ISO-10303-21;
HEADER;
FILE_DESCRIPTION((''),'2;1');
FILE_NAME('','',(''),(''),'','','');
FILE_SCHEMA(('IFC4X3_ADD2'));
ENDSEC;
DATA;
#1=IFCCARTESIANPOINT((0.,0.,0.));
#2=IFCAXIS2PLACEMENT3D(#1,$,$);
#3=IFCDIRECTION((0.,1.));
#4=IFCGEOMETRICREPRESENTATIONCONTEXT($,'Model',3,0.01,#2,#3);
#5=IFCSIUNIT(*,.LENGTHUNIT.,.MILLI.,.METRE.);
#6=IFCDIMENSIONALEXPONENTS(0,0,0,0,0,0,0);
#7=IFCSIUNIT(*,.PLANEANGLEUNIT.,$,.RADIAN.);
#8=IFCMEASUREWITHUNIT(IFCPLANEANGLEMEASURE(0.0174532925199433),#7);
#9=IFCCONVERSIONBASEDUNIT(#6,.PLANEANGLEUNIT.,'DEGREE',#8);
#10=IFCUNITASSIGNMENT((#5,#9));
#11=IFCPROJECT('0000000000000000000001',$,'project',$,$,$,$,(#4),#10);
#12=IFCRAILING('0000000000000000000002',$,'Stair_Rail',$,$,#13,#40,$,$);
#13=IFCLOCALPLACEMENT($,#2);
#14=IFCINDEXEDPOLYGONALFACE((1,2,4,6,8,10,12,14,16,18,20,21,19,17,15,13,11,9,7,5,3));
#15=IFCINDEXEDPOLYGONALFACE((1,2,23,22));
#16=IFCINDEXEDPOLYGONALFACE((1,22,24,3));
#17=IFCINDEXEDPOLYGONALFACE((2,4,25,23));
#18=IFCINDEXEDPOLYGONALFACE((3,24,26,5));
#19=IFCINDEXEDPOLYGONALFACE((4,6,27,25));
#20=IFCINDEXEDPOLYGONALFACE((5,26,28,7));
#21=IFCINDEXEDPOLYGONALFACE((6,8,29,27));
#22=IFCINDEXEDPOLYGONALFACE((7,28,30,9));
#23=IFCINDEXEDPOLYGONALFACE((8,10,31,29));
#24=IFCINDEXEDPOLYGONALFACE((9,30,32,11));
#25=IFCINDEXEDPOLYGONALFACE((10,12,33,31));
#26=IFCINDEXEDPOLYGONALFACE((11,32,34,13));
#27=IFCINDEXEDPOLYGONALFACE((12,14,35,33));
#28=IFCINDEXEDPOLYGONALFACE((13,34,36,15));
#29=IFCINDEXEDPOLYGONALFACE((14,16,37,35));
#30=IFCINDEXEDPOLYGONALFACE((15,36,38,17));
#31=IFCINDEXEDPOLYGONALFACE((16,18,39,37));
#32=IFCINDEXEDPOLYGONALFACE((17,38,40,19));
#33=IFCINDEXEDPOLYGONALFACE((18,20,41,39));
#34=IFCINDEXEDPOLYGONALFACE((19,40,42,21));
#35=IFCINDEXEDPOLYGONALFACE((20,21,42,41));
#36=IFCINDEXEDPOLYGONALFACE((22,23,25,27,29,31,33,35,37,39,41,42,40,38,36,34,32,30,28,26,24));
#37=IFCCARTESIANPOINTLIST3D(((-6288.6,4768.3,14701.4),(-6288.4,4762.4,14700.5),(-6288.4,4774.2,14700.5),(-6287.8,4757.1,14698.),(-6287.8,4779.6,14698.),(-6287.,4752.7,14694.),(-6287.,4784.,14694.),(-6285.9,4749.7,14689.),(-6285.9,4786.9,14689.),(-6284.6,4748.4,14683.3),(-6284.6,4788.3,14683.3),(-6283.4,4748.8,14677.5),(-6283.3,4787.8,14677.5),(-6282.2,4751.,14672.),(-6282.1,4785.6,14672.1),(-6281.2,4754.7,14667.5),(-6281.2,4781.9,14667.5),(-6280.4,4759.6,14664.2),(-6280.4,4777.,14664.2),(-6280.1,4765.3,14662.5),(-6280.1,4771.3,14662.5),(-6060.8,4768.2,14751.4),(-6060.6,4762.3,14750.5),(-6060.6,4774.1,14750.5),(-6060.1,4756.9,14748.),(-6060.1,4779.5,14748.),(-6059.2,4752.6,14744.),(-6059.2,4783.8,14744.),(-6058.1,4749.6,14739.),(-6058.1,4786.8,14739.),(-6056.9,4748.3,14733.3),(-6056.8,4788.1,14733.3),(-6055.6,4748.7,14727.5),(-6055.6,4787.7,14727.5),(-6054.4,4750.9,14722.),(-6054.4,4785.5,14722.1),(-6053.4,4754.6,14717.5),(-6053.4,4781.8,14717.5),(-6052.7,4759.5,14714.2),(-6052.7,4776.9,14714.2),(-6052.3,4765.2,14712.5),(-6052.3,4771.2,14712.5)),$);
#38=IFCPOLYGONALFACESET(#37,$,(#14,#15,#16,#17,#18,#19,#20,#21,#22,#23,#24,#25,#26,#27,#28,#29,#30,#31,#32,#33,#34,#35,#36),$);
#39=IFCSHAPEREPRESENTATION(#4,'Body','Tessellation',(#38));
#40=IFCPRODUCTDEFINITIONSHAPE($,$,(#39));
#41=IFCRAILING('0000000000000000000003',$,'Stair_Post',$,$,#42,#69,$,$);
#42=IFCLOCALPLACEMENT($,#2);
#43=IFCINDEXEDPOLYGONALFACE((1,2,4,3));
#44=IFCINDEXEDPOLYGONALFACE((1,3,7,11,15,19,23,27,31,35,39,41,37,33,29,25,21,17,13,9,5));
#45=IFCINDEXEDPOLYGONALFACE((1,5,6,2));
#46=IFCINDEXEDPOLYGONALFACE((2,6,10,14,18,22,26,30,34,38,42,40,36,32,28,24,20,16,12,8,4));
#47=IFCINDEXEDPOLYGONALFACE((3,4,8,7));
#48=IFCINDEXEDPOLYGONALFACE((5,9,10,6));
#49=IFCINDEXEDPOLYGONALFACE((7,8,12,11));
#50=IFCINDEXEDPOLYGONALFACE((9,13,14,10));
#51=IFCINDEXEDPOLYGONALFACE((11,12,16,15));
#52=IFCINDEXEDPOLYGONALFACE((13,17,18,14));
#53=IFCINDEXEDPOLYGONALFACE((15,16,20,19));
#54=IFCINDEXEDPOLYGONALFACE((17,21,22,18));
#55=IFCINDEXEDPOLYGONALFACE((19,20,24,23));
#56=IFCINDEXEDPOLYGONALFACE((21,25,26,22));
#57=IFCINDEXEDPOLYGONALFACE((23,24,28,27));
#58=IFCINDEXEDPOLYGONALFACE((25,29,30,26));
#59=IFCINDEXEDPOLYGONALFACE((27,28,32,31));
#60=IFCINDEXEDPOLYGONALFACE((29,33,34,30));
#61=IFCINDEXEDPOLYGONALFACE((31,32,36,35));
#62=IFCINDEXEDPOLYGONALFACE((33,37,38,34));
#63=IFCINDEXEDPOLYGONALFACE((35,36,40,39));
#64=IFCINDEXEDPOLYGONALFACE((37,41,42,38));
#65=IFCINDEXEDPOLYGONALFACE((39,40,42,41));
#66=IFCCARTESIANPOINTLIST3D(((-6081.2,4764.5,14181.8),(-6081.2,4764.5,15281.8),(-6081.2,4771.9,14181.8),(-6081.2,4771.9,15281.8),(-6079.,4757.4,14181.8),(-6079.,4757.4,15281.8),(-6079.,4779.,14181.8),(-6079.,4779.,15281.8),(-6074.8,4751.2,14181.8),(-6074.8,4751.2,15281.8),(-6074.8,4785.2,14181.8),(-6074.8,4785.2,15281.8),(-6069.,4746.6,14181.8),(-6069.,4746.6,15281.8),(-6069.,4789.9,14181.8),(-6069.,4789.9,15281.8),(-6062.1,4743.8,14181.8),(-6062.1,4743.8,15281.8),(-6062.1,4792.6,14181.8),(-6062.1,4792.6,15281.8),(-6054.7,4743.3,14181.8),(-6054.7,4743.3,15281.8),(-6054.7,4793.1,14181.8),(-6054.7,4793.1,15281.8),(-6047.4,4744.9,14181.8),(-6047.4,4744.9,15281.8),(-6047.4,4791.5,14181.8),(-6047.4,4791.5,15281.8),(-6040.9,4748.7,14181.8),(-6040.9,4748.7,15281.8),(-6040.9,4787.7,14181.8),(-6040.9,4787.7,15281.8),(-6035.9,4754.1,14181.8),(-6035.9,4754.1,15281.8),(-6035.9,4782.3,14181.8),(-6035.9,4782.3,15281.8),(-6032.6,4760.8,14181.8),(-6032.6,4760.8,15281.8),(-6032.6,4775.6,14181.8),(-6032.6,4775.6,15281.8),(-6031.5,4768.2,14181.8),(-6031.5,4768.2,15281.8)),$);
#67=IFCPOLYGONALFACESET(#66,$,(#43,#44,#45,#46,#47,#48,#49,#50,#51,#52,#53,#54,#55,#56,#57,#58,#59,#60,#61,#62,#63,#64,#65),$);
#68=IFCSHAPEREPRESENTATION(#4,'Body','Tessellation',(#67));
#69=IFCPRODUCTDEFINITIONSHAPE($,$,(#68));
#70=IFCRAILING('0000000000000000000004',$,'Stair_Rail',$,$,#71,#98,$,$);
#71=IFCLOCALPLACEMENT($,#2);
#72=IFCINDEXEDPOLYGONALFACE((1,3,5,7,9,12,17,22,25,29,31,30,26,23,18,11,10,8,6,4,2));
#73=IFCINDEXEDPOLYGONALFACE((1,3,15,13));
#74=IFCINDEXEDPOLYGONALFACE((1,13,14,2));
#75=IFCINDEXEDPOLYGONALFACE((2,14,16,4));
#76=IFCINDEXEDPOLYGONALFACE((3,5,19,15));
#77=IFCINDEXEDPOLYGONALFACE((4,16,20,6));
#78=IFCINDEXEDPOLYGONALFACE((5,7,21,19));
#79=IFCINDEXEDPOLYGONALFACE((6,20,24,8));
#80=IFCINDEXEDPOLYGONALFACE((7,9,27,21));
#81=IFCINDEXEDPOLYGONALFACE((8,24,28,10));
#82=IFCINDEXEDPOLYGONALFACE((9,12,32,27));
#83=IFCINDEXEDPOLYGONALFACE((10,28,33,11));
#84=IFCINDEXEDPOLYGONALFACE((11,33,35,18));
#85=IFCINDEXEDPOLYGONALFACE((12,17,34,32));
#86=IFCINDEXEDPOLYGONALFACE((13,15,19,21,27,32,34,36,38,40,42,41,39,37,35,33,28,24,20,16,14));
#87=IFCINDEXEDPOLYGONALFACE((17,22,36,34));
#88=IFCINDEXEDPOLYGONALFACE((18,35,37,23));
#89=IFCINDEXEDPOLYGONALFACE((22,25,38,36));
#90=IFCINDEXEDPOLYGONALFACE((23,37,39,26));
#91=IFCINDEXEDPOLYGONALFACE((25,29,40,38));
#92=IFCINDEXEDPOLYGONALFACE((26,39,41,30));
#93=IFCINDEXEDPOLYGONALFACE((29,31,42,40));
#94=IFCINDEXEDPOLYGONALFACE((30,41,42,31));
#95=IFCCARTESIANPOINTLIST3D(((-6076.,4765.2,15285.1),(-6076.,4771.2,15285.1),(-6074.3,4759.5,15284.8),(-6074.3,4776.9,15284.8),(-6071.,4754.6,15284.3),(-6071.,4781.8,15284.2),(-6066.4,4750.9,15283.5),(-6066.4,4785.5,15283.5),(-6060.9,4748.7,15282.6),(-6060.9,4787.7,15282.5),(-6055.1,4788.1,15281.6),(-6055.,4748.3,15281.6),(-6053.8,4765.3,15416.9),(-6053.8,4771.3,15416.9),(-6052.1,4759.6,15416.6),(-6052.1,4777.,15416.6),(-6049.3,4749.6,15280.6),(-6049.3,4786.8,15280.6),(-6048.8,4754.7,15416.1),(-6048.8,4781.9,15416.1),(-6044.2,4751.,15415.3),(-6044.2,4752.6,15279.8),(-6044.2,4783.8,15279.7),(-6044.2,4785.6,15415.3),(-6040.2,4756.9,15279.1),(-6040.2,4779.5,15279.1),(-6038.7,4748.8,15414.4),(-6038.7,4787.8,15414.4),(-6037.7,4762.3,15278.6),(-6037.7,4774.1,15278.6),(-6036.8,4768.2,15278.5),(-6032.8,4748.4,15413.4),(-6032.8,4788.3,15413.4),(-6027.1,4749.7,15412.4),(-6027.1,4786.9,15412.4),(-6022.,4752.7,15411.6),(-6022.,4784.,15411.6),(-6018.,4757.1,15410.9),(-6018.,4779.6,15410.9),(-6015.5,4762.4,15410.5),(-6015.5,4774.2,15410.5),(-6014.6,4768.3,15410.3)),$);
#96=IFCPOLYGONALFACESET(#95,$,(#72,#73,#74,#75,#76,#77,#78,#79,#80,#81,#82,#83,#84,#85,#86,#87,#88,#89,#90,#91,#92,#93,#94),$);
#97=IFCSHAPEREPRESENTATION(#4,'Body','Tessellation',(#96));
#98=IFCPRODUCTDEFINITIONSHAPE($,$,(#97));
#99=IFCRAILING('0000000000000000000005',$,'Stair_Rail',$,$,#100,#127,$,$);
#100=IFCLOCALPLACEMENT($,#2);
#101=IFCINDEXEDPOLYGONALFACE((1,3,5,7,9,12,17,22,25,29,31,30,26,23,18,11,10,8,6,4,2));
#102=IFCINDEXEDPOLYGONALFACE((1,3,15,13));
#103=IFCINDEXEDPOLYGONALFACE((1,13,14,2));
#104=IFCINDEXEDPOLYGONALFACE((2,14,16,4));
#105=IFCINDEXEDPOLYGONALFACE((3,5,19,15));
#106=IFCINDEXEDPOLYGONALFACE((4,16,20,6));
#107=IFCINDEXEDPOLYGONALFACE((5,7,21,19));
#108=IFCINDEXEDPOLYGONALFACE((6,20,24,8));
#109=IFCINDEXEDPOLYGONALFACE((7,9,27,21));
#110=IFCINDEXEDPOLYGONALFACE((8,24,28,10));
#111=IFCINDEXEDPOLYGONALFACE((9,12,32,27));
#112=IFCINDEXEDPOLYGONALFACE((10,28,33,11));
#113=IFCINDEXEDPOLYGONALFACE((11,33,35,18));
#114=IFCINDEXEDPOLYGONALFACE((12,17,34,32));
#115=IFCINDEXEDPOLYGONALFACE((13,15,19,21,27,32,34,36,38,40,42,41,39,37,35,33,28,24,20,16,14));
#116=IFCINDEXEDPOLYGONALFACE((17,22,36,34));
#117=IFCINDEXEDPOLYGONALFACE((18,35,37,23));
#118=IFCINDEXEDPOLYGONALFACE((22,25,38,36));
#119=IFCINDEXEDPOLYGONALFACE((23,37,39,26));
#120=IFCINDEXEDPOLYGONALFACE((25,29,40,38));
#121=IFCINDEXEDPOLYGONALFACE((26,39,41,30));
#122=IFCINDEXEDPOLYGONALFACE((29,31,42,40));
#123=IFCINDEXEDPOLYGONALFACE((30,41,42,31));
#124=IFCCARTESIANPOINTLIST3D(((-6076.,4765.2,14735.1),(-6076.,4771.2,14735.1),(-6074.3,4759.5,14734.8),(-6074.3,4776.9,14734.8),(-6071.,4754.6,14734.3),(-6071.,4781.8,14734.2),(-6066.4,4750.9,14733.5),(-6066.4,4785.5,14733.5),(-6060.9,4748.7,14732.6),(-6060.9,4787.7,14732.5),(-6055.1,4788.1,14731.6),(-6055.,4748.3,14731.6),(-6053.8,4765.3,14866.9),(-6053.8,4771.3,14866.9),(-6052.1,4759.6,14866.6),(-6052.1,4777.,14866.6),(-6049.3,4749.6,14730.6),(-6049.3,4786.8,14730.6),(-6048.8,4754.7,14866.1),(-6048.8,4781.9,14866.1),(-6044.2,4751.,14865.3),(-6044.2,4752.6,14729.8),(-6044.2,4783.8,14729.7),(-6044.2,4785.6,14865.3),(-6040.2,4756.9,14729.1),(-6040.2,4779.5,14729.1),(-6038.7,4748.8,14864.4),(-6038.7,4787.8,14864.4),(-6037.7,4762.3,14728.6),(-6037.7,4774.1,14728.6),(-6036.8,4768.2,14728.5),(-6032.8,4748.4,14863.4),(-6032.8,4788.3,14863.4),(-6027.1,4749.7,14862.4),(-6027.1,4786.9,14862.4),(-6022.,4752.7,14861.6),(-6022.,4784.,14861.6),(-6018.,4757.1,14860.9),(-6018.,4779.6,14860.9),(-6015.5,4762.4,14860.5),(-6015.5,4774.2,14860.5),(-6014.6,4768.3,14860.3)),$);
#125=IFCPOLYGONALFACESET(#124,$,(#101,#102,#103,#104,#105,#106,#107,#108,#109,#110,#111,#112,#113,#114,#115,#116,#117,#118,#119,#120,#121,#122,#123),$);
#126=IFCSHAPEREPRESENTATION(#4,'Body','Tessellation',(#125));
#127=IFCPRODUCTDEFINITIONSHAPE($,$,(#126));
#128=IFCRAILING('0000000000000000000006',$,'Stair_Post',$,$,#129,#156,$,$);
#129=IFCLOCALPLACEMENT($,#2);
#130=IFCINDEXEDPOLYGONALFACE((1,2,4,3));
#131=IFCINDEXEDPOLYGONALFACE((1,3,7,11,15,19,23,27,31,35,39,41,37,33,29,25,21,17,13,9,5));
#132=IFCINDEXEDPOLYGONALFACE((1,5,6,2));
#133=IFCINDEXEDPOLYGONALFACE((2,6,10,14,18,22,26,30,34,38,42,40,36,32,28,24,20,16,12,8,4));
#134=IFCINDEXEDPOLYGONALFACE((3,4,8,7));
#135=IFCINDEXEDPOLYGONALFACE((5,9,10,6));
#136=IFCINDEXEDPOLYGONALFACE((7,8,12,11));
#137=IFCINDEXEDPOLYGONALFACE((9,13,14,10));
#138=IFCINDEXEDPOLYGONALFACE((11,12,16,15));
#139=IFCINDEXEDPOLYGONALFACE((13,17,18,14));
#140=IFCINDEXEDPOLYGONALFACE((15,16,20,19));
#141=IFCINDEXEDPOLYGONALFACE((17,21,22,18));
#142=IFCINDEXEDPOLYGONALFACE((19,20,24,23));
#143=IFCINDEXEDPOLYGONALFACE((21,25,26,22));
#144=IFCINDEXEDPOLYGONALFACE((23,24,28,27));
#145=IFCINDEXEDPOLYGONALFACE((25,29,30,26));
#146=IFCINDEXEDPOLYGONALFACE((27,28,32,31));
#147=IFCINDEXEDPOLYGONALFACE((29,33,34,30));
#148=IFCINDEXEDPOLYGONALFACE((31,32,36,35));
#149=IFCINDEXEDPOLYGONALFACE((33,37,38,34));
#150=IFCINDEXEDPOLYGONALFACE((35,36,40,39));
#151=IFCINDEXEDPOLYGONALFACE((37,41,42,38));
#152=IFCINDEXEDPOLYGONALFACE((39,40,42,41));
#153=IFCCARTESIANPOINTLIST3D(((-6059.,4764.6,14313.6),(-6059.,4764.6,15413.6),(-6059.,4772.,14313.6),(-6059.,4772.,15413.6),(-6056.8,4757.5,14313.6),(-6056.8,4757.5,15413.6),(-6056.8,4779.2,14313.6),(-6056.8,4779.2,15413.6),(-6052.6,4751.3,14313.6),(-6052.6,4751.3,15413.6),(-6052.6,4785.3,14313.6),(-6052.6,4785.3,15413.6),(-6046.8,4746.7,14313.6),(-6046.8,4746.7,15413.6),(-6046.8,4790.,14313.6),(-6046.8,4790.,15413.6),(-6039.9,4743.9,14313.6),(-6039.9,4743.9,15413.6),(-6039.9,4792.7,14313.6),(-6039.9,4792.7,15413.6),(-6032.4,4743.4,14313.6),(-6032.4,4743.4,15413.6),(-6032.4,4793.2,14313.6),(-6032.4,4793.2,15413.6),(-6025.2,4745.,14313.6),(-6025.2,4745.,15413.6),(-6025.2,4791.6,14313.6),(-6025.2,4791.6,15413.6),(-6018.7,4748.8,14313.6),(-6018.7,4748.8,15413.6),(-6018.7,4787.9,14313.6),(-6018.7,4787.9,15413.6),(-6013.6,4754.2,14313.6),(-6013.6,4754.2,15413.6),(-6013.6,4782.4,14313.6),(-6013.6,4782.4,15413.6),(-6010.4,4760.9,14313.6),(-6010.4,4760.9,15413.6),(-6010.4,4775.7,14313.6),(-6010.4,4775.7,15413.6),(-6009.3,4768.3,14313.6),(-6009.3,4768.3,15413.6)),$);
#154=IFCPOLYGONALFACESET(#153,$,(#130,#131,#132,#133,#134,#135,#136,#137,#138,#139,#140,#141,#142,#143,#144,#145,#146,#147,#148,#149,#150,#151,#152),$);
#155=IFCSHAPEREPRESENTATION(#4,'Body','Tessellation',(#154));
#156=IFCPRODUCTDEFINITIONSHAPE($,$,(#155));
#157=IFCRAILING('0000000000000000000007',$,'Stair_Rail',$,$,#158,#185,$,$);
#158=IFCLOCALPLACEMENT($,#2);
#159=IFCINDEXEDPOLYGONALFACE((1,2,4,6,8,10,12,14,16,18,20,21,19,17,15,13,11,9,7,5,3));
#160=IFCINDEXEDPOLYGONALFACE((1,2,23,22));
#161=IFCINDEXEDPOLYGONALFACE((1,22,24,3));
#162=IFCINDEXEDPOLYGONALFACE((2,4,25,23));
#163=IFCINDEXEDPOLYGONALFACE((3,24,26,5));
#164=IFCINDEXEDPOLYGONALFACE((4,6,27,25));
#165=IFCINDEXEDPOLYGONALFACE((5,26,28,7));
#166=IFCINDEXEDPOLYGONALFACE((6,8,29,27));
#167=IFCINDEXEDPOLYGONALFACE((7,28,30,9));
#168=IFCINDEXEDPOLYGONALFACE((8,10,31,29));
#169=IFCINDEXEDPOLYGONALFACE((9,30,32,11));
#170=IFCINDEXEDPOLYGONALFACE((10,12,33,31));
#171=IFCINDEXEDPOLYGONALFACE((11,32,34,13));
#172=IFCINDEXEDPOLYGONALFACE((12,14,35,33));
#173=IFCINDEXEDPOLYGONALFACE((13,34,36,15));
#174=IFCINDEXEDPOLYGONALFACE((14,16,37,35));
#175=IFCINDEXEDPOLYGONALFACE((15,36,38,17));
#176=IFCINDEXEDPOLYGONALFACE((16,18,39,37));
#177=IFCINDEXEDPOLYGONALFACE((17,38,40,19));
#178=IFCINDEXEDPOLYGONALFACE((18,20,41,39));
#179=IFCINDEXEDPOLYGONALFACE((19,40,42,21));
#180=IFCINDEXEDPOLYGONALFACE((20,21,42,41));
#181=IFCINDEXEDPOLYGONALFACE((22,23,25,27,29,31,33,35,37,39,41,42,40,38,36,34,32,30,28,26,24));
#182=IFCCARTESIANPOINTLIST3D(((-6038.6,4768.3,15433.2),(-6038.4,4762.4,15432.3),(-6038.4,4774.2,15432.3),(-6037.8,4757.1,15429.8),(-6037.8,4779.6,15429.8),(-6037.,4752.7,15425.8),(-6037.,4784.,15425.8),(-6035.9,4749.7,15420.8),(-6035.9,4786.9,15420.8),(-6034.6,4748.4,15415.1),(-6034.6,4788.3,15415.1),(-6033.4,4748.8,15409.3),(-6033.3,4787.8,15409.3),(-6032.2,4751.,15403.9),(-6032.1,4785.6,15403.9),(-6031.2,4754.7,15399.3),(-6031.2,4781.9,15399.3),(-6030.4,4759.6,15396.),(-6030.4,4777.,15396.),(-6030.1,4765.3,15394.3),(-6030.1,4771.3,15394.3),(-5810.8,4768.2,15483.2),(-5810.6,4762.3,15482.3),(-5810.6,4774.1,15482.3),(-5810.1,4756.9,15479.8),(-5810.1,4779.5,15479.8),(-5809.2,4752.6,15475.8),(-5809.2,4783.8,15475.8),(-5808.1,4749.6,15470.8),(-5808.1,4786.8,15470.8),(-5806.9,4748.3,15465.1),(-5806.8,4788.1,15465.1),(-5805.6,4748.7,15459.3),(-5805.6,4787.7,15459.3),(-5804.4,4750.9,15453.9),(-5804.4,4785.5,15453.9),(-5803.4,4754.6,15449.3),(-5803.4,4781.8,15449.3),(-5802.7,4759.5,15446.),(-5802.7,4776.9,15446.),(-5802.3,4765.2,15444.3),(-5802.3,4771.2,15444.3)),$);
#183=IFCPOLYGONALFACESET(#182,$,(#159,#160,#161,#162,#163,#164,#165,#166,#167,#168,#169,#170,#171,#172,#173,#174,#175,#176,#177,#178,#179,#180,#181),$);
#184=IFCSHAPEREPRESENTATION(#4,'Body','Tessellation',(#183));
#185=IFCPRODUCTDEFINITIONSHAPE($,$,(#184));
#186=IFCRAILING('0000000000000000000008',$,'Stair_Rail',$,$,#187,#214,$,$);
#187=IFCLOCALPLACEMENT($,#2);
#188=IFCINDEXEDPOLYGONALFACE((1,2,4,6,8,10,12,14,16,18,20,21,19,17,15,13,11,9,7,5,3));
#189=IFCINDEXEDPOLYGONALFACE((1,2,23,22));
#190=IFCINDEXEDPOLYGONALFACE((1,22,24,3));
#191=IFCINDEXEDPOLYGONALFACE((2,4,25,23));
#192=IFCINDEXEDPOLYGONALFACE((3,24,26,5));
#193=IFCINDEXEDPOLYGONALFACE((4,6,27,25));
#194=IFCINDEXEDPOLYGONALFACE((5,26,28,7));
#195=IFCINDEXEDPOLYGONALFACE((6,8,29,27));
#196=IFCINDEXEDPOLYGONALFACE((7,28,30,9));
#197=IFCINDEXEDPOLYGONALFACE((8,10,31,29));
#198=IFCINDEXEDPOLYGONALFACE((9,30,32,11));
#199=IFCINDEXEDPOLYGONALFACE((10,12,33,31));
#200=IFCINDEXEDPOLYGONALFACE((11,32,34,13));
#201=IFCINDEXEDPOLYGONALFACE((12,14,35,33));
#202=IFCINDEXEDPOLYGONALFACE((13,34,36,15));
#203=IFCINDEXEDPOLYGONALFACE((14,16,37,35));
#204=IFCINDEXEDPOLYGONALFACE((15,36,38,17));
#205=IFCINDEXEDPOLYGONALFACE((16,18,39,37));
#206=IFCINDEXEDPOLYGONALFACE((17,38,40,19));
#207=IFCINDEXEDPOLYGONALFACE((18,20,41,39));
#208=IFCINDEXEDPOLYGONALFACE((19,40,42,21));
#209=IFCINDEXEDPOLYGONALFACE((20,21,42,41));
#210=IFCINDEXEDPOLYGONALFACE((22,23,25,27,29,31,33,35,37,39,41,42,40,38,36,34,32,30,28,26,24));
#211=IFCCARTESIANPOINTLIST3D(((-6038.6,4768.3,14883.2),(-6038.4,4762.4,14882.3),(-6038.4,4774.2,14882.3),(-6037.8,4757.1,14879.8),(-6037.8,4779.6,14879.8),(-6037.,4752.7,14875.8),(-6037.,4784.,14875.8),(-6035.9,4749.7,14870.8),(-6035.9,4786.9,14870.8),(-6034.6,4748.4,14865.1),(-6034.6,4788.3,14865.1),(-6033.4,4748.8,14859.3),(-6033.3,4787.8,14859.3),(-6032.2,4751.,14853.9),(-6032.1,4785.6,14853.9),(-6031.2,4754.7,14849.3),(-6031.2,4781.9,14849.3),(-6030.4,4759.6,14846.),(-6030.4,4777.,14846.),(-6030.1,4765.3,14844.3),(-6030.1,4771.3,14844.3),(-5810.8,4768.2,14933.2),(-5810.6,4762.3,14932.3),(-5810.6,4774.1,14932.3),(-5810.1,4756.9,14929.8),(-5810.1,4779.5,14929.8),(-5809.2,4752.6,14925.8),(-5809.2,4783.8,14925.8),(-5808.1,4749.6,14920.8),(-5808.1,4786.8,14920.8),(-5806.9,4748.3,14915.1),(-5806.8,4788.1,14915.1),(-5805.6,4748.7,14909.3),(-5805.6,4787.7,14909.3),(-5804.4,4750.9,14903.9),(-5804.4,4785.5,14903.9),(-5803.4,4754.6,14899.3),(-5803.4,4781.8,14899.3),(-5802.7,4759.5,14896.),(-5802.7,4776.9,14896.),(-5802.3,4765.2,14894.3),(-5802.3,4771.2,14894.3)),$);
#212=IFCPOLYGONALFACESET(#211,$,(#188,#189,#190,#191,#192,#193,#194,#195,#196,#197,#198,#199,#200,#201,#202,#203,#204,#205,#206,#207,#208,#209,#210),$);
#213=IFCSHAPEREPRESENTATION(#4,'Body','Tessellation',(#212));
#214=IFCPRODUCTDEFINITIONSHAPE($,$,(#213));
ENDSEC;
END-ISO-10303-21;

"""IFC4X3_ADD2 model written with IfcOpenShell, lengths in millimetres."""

from ifc_helpers import new_model, entity, si_unit, converted_unit, direction, frame, origin, context, project, circle, extrude, element, save


model = new_model("IFC4X3_ADD2")

# Units and contexts
model_context = context("Model", 3, precision=0.01, world=origin(), true_north=direction((0.0, 1.0)))
ifc_project = project(units=[si_unit("LENGTHUNIT", "METRE", prefix="MILLI"), converted_unit("PLANEANGLEUNIT", "DEGREE", entity("IfcPlaneAngleMeasure", 0.0174532925199433), si_unit("PLANEANGLEUNIT", "RADIAN"), dimensions=[0, 0, 0, 0, 0, 0, 0])], contexts=[model_context])

# Railings
element("IfcRailing", 1, Name="Stair_Rail", context=model_context, shape_type="SweptSolid", body=[
    entity("IfcSweptDiskSolid", entity("IfcPolyline", [entity("IfcCartesianPoint", [-6284.3, 4768.3, 14681.8]), entity("IfcCartesianPoint", [-6056.5, 4768.2, 14731.8])]), 20.0),
])
element("IfcRailing", 2, Name="Stair_Post", context=model_context, shape_type="SweptSolid", body=[
    extrude(circle(Radius=25.0), frame((-6056.5, 4768.2, 14181.8)), (0.0, 0.0, 1.0), 1100.0),
])
element("IfcRailing", 3, Name="Stair_Rail", context=model_context, shape_type="SweptSolid", body=[
    entity("IfcSweptDiskSolid", entity("IfcPolyline", [entity("IfcCartesianPoint", [-6056.5, 4768.2, 15281.8]), entity("IfcCartesianPoint", [-6034.3, 4768.3, 15413.6])]), 20.0),
])
element("IfcRailing", 4, Name="Stair_Rail", context=model_context, shape_type="SweptSolid", body=[
    entity("IfcSweptDiskSolid", entity("IfcPolyline", [entity("IfcCartesianPoint", [-6056.5, 4768.2, 14731.8]), entity("IfcCartesianPoint", [-6034.3, 4768.3, 14863.6])]), 20.0),
])
element("IfcRailing", 5, Name="Stair_Post", context=model_context, shape_type="SweptSolid", body=[
    extrude(circle(Radius=25.0), frame((-6034.3, 4768.3, 14313.6)), (0.0, 0.0, 1.0), 1100.0),
])
element("IfcRailing", 6, Name="Stair_Rail", context=model_context, shape_type="SweptSolid", body=[
    entity("IfcSweptDiskSolid", entity("IfcPolyline", [entity("IfcCartesianPoint", [-6034.3, 4768.3, 15413.6]), entity("IfcCartesianPoint", [-5806.5, 4768.2, 15463.6])]), 20.0),
])
element("IfcRailing", 7, Name="Stair_Rail", context=model_context, shape_type="SweptSolid", body=[
    entity("IfcSweptDiskSolid", entity("IfcPolyline", [entity("IfcCartesianPoint", [-6034.3, 4768.3, 14863.6]), entity("IfcCartesianPoint", [-5806.5, 4768.2, 14913.6])]), 20.0),
])

save(model, "model.ifc")
